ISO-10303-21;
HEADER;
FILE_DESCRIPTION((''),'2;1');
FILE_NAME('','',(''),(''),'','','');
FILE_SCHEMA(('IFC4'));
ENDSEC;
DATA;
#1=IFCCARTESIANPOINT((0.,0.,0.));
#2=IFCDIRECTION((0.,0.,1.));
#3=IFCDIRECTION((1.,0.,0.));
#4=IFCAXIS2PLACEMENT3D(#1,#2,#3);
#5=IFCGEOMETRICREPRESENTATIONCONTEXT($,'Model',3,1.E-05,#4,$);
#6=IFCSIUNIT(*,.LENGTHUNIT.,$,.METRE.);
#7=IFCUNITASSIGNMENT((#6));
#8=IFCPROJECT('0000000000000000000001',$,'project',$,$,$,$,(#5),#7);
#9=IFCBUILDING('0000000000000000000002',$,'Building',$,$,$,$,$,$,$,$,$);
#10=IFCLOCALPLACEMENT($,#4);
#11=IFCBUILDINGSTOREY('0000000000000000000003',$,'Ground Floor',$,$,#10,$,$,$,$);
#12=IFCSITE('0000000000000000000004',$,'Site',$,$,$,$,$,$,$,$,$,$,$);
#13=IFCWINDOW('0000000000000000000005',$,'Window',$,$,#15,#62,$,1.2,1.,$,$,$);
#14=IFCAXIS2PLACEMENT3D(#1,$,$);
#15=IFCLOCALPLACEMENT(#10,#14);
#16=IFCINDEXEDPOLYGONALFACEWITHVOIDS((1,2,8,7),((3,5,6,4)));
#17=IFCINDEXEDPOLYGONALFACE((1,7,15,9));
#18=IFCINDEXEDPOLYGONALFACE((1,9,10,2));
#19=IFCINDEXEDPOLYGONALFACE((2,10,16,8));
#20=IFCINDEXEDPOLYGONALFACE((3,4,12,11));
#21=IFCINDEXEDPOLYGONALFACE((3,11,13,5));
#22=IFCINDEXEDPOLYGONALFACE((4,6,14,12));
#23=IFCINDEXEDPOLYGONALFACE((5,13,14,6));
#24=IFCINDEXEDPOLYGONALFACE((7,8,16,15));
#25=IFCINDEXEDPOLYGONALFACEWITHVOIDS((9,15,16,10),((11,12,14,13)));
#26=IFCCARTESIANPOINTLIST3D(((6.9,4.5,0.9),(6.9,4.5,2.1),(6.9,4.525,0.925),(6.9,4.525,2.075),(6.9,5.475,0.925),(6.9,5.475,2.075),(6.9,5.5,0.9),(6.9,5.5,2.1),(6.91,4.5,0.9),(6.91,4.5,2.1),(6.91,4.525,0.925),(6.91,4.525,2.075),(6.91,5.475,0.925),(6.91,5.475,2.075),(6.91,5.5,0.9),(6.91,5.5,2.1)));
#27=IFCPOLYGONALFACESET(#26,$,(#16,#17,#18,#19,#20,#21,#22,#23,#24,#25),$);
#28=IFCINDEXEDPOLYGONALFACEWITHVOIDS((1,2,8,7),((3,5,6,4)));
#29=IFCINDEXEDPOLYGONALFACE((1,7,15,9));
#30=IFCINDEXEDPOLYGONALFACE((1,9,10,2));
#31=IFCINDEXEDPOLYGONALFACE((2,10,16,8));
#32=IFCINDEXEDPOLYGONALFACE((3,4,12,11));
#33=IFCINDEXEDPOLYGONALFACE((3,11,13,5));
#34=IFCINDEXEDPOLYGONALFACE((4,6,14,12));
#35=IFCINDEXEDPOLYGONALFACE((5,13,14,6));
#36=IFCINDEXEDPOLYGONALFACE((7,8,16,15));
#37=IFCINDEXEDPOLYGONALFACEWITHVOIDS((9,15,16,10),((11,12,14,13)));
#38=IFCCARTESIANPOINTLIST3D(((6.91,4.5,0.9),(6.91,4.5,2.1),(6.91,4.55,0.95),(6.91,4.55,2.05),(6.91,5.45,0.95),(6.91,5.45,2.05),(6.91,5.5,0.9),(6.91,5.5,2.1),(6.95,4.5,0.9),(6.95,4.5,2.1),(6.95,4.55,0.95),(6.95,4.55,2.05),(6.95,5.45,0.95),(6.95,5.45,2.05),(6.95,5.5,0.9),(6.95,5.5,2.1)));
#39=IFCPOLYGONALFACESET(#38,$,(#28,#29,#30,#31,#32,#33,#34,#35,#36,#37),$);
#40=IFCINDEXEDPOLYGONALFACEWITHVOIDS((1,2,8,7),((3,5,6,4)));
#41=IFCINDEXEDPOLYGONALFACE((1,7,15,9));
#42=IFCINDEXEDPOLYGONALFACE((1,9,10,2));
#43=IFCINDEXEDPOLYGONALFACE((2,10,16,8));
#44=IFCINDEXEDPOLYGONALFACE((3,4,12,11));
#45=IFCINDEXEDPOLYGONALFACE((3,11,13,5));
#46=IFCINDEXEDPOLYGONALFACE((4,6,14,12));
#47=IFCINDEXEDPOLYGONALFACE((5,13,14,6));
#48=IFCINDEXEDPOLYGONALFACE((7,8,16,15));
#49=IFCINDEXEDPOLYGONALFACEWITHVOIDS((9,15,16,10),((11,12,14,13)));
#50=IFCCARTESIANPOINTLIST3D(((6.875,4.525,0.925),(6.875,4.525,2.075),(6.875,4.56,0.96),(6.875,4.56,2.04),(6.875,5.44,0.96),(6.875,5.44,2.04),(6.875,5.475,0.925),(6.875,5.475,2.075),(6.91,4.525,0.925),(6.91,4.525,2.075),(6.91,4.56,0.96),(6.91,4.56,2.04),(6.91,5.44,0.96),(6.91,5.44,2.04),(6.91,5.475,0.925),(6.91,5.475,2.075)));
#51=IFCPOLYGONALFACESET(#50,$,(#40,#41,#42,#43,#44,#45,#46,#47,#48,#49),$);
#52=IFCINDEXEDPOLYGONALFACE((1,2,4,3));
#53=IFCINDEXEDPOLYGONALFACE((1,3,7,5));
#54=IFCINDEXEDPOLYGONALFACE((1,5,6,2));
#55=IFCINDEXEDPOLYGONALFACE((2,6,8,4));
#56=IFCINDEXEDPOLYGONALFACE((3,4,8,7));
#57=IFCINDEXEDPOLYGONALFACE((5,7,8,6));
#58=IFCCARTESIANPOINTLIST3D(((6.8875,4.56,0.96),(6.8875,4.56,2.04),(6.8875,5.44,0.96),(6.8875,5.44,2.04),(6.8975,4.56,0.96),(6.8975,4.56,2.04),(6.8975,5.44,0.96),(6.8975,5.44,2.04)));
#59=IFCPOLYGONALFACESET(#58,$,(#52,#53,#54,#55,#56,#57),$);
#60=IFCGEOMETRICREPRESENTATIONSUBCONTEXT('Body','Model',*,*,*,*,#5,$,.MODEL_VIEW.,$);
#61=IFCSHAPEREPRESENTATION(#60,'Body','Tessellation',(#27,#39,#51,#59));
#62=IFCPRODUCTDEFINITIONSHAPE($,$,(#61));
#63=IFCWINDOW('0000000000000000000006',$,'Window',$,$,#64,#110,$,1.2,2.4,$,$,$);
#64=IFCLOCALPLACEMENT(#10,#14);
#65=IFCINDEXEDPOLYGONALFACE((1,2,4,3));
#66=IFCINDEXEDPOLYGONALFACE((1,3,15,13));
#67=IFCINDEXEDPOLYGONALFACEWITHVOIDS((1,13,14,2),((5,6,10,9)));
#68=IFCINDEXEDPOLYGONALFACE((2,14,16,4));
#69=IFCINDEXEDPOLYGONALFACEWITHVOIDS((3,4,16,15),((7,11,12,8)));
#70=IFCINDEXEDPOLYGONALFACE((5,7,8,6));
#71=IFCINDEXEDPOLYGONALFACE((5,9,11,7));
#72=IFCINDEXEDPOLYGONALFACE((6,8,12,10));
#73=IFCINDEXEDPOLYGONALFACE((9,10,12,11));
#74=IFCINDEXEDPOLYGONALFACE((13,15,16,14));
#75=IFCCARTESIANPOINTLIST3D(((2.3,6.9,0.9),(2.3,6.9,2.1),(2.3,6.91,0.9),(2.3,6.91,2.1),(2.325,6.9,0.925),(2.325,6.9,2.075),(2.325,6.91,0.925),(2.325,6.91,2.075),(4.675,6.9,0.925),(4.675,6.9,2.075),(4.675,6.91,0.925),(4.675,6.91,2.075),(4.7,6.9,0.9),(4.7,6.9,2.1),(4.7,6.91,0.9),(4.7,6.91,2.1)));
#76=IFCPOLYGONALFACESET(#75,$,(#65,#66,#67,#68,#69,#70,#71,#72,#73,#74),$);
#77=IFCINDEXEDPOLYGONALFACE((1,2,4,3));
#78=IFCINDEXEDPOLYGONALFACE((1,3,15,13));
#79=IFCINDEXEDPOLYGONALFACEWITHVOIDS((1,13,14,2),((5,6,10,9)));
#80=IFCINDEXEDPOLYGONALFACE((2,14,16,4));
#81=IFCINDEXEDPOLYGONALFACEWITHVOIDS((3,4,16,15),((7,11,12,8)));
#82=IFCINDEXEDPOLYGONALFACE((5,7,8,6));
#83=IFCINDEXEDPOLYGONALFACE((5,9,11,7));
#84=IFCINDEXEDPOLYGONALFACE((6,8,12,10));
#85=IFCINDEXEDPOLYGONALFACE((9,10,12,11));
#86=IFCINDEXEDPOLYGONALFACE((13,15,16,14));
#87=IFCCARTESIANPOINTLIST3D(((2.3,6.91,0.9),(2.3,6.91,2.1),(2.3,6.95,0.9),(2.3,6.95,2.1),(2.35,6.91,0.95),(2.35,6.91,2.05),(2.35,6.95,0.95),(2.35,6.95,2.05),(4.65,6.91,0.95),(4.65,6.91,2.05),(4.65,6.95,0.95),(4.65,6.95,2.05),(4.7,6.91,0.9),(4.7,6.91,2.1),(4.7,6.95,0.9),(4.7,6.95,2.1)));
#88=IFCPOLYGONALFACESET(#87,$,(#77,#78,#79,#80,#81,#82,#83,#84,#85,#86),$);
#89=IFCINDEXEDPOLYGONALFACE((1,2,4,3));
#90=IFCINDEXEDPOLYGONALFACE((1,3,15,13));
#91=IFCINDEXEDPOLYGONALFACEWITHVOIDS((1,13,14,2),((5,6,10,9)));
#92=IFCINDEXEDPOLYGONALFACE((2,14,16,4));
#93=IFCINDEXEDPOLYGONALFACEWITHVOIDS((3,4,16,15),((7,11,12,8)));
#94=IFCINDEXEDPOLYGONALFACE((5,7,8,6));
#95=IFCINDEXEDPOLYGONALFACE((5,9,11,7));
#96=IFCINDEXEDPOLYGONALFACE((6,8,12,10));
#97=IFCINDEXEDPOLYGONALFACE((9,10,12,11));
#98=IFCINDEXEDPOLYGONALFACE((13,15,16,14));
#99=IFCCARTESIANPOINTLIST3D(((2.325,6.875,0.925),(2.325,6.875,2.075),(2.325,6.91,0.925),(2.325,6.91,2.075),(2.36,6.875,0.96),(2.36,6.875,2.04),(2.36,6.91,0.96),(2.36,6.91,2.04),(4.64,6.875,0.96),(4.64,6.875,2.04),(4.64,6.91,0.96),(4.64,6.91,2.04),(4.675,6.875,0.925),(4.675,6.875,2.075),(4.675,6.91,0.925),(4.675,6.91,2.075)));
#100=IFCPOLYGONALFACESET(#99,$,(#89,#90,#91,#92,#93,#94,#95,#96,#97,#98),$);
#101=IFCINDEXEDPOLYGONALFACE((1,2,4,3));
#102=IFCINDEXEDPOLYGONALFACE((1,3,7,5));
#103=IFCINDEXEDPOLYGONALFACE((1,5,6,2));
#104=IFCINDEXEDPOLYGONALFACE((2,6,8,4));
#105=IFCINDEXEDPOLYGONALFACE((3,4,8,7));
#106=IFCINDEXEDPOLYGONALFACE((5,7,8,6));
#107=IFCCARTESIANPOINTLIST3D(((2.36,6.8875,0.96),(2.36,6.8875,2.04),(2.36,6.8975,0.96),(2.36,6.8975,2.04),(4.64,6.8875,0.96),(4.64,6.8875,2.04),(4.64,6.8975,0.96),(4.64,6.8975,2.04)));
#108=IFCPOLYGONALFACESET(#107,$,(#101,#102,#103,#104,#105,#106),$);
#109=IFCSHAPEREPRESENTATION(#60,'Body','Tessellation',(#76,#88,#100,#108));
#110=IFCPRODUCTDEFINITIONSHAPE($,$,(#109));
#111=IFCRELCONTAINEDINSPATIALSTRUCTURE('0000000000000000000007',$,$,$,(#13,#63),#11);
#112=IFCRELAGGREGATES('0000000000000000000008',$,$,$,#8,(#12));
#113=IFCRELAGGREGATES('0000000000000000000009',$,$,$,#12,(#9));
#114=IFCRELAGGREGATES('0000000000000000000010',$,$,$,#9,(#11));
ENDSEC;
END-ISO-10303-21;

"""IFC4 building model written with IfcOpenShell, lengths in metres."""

from ifc_helpers import new_model, si_unit, frame, origin_with_axes, place, context, subcontext, project, spatial, line, indexed_curve, outline, extrude, element, save


model = new_model("IFC4")

# Units and contexts
model_context = context("Model", 3, precision=1e-05, world=origin_with_axes())
body_context = subcontext(model_context, "Body", "Model", "MODEL_VIEW")
ifc_project = project(units=[si_unit("LENGTHUNIT", "METRE")], contexts=[model_context])

# Site, building, storey
site = spatial("IfcSite", under=ifc_project, Name="Site")
building = spatial("IfcBuilding", under=site, Name="Building")
storey_placement = place(None, origin_with_axes())
storey = spatial("IfcBuildingStorey", under=building, at=storey_placement, Name="Ground Floor")

# Windows
window_1_placement = place(storey_placement, frame((7.0, 4.5, 0.9), z_axis=(0.0, 0.0, 1.0), x_axis=(0.0, 1.0, 0.0)))
element("IfcWindow", 1, at=window_1_placement, inside=storey, Name="Window", OverallHeight=1.2, OverallWidth=1.0, context=body_context, shape_type="SweptSolid", body=[
    extrude(outline(indexed_curve([(0.0, 0.0), (1.0, 0.0), (1.0, 1.2), (0.0, 1.2)], segments=[line(1, 2, 3, 4, 1)]), holes=[indexed_curve([(0.025, 0.025), (0.975, 0.025), (0.975, 1.175), (0.025, 1.175)], segments=[line(1, 2, 3, 4, 1)])]), frame((0.0, 0.09, 0.0), z_axis=(0.0, -1.0, 0.0), x_axis=(1.0, 0.0, 0.0)), (0.0, 0.0, -1.0), 0.01),
    extrude(outline(indexed_curve([(0.0, 0.0), (1.0, 0.0), (1.0, 1.2), (0.0, 1.2)], segments=[line(1, 2, 3, 4, 1)]), holes=[indexed_curve([(0.05, 0.05), (0.95, 0.05), (0.95, 1.15), (0.05, 1.15)], segments=[line(1, 2, 3, 4, 1)])]), frame((0.0, 0.05, 0.0), z_axis=(0.0, -1.0, 0.0), x_axis=(1.0, 0.0, 0.0)), (0.0, 0.0, -1.0), 0.04),
    extrude(outline(indexed_curve([(0.0, 0.0), (0.95, 0.0), (0.95, 1.15), (0.0, 1.15)], segments=[line(1, 2, 3, 4, 1)]), holes=[indexed_curve([(0.035, 0.035), (0.915, 0.035), (0.915, 1.115), (0.035, 1.115)], segments=[line(1, 2, 3, 4, 1)])]), frame((0.025, 0.09, 0.025), z_axis=(0.0, -1.0, 0.0), x_axis=(1.0, 0.0, 0.0)), (0.0, 0.0, -1.0), 0.035),
    extrude(outline(indexed_curve([(0.035, 0.035), (0.915, 0.035), (0.915, 1.115), (0.035, 1.115)], segments=[line(1, 2, 3, 4, 1)])), frame((0.025, 0.1025, 0.025), z_axis=(0.0, -1.0, 0.0), x_axis=(1.0, 0.0, 0.0)), (0.0, 0.0, -1.0), 0.01),
])
window_2_placement = place(storey_placement, frame((4.7, 7.0, 0.9), z_axis=(0.0, 0.0, 1.0), x_axis=(-1.0, 0.0, 0.0)))
element("IfcWindow", 2, at=window_2_placement, inside=storey, Name="Window", OverallHeight=1.2, OverallWidth=2.4, context=body_context, shape_type="SweptSolid", body=[
    extrude(outline(indexed_curve([(0.0, 0.0), (2.4, 0.0), (2.4, 1.2), (0.0, 1.2)], segments=[line(1, 2, 3, 4, 1)]), holes=[indexed_curve([(0.025, 0.025), (2.375, 0.025), (2.375, 1.175), (0.025, 1.175)], segments=[line(1, 2, 3, 4, 1)])]), frame((0.0, 0.09, 0.0), z_axis=(0.0, -1.0, 0.0), x_axis=(1.0, 0.0, 0.0)), (0.0, 0.0, -1.0), 0.01),
    extrude(outline(indexed_curve([(0.0, 0.0), (2.4, 0.0), (2.4, 1.2), (0.0, 1.2)], segments=[line(1, 2, 3, 4, 1)]), holes=[indexed_curve([(0.05, 0.05), (2.35, 0.05), (2.35, 1.15), (0.05, 1.15)], segments=[line(1, 2, 3, 4, 1)])]), frame((0.0, 0.05, 0.0), z_axis=(0.0, -1.0, 0.0), x_axis=(1.0, 0.0, 0.0)), (0.0, 0.0, -1.0), 0.04),
    extrude(outline(indexed_curve([(0.0, 0.0), (2.35, 0.0), (2.35, 1.15), (0.0, 1.15)], segments=[line(1, 2, 3, 4, 1)]), holes=[indexed_curve([(0.035, 0.035), (2.315, 0.035), (2.315, 1.115), (0.035, 1.115)], segments=[line(1, 2, 3, 4, 1)])]), frame((0.025, 0.09, 0.025), z_axis=(0.0, -1.0, 0.0), x_axis=(1.0, 0.0, 0.0)), (0.0, 0.0, -1.0), 0.035),
    extrude(outline(indexed_curve([(0.035, 0.035), (2.315, 0.035), (2.315, 1.115), (0.035, 1.115)], segments=[line(1, 2, 3, 4, 1)])), frame((0.025, 0.1025, 0.025), z_axis=(0.0, -1.0, 0.0), x_axis=(1.0, 0.0, 0.0)), (0.0, 0.0, -1.0), 0.01),
])

save(model, "model.ifc")
